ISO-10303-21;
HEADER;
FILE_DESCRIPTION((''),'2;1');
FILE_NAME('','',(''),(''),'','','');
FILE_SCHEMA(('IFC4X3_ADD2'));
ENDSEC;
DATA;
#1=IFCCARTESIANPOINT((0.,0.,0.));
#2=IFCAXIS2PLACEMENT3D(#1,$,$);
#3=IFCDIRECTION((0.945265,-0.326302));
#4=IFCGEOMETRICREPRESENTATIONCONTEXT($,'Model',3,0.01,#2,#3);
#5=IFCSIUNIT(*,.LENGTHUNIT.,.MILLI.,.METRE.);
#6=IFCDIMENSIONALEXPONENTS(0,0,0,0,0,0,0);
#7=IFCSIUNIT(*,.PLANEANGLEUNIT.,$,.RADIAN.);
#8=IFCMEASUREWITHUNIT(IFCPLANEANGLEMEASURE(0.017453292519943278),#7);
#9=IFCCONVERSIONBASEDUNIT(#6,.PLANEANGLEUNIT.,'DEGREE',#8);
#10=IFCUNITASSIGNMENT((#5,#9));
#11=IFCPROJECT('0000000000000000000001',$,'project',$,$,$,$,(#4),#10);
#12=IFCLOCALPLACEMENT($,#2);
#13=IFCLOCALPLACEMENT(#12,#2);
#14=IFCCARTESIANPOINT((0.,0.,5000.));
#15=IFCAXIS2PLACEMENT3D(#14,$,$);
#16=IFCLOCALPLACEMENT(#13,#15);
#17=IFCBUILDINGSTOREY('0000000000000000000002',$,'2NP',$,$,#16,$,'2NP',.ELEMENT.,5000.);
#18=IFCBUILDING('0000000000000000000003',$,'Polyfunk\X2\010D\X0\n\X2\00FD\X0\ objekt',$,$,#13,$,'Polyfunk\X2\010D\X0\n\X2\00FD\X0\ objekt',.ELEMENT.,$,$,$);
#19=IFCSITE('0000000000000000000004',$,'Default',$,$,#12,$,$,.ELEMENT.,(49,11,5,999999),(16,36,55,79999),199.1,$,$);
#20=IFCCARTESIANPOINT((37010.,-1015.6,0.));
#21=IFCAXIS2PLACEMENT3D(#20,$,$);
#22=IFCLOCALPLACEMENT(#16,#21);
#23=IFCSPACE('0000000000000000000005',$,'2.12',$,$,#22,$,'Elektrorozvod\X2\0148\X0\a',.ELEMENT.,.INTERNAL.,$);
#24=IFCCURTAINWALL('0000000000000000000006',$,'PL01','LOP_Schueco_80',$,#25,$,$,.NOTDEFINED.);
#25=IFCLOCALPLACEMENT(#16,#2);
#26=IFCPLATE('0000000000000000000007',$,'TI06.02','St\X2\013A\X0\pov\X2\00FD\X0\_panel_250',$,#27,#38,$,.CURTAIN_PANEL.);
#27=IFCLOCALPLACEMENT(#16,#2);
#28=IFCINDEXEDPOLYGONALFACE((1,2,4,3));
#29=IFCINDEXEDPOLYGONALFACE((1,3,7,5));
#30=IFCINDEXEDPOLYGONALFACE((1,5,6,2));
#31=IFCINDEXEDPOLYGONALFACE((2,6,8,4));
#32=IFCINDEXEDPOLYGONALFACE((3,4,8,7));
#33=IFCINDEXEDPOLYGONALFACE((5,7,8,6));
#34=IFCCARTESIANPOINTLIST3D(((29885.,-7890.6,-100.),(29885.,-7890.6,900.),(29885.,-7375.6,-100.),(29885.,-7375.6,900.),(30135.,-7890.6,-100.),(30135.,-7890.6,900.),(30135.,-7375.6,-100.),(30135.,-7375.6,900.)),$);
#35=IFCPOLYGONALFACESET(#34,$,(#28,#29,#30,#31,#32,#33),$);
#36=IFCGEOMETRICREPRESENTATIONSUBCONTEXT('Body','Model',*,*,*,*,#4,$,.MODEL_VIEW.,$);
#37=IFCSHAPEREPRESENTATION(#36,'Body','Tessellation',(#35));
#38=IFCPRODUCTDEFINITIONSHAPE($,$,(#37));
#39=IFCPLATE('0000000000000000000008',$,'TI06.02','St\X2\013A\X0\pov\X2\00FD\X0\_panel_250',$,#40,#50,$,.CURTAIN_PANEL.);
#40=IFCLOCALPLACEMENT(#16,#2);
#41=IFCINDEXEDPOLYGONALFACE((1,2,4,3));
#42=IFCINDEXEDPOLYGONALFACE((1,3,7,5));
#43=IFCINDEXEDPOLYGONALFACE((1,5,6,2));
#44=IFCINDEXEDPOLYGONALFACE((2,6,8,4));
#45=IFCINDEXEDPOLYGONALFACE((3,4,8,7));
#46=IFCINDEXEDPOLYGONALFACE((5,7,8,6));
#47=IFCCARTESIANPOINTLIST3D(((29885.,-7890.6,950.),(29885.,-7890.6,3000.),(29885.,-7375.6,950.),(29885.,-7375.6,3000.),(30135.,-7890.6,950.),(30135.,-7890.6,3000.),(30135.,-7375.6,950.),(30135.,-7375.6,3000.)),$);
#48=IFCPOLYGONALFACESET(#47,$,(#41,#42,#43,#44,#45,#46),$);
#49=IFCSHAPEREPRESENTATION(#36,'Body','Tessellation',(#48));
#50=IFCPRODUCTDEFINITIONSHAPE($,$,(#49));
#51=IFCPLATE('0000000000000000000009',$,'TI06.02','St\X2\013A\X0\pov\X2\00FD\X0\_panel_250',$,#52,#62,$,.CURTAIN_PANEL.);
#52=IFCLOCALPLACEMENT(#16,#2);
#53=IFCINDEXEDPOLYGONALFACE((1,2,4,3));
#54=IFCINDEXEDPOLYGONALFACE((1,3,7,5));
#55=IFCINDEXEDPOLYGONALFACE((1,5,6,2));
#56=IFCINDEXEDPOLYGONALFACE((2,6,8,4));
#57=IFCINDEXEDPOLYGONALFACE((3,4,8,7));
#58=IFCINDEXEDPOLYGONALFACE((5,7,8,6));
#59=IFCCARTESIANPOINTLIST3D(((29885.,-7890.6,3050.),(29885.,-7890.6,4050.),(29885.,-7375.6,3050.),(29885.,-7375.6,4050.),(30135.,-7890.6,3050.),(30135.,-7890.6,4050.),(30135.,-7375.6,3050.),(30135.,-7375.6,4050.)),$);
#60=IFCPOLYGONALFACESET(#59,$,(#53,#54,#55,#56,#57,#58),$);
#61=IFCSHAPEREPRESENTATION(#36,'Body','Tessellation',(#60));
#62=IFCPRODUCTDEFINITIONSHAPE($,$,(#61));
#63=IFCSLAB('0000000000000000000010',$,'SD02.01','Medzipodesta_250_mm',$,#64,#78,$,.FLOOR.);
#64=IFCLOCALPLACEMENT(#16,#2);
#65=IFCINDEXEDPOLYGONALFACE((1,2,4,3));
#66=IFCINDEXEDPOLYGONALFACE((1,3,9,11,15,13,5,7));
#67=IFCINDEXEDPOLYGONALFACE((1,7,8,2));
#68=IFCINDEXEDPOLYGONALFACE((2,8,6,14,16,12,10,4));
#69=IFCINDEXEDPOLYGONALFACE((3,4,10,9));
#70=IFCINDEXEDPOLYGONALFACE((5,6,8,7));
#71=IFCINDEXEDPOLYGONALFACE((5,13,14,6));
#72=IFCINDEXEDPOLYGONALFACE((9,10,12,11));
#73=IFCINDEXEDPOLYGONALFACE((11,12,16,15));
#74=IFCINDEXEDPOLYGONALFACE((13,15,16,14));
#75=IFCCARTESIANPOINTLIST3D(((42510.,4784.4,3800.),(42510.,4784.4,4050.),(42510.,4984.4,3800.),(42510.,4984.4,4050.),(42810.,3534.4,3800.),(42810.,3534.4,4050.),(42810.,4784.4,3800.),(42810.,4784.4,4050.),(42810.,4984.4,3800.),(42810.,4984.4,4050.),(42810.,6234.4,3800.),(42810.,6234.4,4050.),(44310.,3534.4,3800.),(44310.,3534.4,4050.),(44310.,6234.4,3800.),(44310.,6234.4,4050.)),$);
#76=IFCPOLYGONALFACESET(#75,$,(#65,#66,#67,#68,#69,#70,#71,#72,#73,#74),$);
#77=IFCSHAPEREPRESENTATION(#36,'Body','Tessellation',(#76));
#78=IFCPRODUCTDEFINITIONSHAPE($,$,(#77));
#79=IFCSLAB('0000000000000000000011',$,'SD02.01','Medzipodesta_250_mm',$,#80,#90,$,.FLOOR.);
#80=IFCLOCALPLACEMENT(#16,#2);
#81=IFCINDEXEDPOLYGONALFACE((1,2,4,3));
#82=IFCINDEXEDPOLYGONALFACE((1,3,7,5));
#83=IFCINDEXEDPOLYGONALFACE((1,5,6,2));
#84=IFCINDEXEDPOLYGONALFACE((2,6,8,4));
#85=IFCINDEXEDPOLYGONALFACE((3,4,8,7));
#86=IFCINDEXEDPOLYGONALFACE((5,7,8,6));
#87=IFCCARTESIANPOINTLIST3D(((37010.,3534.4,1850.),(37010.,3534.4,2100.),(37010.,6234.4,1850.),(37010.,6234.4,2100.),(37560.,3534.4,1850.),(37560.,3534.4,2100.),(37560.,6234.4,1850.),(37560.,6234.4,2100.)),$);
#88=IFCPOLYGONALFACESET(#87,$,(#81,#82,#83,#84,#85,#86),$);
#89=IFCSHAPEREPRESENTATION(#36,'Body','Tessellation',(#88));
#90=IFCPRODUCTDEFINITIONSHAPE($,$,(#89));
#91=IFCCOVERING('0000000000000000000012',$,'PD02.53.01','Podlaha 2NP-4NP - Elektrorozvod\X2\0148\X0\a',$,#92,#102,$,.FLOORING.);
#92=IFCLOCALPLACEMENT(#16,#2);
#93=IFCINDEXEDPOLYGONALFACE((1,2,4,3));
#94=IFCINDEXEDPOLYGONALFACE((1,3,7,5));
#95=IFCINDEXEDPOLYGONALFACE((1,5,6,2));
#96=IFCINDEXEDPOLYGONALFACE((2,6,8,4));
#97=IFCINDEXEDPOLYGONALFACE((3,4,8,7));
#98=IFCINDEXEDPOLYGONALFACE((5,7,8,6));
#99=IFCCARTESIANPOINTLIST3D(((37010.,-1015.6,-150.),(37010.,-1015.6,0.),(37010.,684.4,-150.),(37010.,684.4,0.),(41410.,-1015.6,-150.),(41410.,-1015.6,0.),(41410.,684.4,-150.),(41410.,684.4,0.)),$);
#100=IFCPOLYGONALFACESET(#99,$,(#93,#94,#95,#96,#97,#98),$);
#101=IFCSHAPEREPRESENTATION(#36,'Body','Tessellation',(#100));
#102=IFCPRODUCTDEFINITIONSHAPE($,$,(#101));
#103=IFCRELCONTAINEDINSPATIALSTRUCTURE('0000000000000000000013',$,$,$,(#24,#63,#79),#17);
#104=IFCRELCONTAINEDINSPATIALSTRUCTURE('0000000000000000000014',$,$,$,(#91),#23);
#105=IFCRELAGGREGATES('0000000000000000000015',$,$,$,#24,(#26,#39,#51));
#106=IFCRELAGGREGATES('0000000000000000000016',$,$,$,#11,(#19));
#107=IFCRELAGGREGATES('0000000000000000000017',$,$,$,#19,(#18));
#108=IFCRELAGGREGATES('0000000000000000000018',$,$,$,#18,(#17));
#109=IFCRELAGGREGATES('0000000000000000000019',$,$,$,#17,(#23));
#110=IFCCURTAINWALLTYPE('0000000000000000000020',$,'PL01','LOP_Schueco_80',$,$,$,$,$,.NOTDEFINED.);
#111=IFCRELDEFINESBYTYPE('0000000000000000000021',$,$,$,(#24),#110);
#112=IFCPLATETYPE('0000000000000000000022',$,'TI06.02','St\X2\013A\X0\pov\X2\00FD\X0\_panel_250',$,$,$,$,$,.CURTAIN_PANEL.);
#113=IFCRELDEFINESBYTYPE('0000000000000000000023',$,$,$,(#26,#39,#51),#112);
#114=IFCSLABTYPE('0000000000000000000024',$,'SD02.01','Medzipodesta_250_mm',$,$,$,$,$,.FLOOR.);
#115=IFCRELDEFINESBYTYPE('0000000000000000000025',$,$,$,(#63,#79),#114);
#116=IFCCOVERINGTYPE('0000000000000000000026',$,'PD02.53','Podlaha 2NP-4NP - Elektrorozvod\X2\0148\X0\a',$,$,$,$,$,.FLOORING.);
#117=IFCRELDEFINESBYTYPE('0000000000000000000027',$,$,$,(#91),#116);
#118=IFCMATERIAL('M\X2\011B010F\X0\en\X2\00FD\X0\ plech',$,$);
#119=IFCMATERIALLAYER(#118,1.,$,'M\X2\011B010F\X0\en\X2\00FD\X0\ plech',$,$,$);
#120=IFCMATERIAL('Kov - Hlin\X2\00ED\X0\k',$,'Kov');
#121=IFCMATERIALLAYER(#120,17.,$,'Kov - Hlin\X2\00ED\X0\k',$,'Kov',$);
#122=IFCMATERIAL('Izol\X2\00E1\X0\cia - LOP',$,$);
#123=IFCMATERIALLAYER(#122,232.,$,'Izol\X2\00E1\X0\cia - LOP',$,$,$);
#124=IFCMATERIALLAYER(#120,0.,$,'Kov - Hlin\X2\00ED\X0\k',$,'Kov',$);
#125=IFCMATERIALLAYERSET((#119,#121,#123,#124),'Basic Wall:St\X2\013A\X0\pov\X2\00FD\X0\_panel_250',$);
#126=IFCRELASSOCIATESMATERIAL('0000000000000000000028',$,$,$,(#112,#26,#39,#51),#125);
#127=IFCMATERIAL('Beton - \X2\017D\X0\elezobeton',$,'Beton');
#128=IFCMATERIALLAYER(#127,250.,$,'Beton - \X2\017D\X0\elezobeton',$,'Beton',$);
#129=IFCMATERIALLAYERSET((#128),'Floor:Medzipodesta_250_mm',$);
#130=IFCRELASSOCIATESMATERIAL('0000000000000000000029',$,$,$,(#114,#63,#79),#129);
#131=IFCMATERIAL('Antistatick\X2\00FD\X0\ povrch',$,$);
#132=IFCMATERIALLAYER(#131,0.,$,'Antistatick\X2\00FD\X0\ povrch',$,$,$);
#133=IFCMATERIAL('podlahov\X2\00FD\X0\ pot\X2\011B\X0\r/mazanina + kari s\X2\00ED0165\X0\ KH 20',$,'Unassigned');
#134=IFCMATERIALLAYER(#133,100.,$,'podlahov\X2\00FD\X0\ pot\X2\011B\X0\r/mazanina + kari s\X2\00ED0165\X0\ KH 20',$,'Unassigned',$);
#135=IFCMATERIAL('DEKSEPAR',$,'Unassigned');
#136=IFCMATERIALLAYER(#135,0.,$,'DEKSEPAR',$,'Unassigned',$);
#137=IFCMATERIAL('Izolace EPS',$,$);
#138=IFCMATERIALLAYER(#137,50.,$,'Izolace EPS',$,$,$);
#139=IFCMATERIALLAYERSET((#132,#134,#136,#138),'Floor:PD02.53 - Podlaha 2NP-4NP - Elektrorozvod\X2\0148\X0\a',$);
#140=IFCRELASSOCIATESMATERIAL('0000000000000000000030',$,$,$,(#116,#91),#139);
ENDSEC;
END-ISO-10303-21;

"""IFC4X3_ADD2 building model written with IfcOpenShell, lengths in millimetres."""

from ifc_helpers import new_model, entity, si_unit, converted_unit, direction, frame, frame_2d, origin, place, context, subcontext, project, spatial, polyline, rectangle, outline, extrude, material, layer, layer_set, layer_usage, type_object, element, aggregate, save


model = new_model("IFC4X3_ADD2")

# Units and contexts
model_context = context("Model", 3, precision=0.01, world=origin(), true_north=direction((0.945265, -0.326302)))
body_context = subcontext(model_context, "Body", "Model", "MODEL_VIEW")
ifc_project = project(units=[si_unit("LENGTHUNIT", "METRE", prefix="MILLI"), converted_unit("PLANEANGLEUNIT", "DEGREE", entity("IfcPlaneAngleMeasure", 0.017453292519943278), si_unit("PLANEANGLEUNIT", "RADIAN"), dimensions=[0, 0, 0, 0, 0, 0, 0])], contexts=[model_context])

# Site, building, storey
site_placement = place(None, origin())
site = spatial("IfcSite", under=ifc_project, at=site_placement, Name="Default", CompositionType="ELEMENT", RefLatitude=(49, 11, 5, 999999), RefLongitude=(16, 36, 55, 79999), RefElevation=199.1)
building_placement = place(site_placement, origin())
building = spatial("IfcBuilding", under=site, at=building_placement, Name="Polyfunkčný objekt", LongName="Polyfunkčný objekt", CompositionType="ELEMENT")
storey_placement = place(building_placement, frame((0.0, 0.0, 5000.0)))
storey = spatial("IfcBuildingStorey", under=building, at=storey_placement, Name="2NP", LongName="2NP", CompositionType="ELEMENT", Elevation=5000.0)

# Curtain wall
curtain_wall_type = type_object("IfcCurtainWallType", Name="PL01", Description="LOP_Schueco_80", PredefinedType="NOTDEFINED")
curtain_wall_1_placement = place(storey_placement, frame((0.0, 0.0, -5000.0)))
curtain_wall_1 = element("IfcCurtainWall", 1, at=curtain_wall_1_placement, inside=storey, type_object=curtain_wall_type, Name="PL01", Description="LOP_Schueco_80", PredefinedType="NOTDEFINED")

# Shared definitions
ifc_material_1 = material(Name="Beton - Železobeton", Category="Beton")

# Shared definitions
ifc_material_2 = material(Name="Měďený plech")
ifc_layer_1 = layer(ifc_material_2, 1.0, Name="Měďený plech")
ifc_material_3 = material(Name="Kov - Hliník", Category="Kov")
ifc_layer_2 = layer(ifc_material_3, 17.0, Name="Kov - Hliník", Category="Kov")
ifc_material_4 = material(Name="Izolácia - LOP")
ifc_layer_3 = layer(ifc_material_4, 232.0, Name="Izolácia - LOP")
ifc_layer_4 = layer(ifc_material_3, 0.0, Name="Kov - Hliník", Category="Kov")
ifc_layer_set_1 = layer_set([ifc_layer_1, ifc_layer_2, ifc_layer_3, ifc_layer_4], Name="Basic Wall:Stĺpový_panel_250")
plate_type = type_object("IfcPlateType", Name="TI06.02", Description="Stĺpový_panel_250", PredefinedType="CURTAIN_PANEL", material=ifc_layer_set_1)

# Plates
ifc_layer_usage_1 = layer_usage(ifc_layer_set_1, "AXIS2", "POSITIVE", -125.0)
plate_1_placement = place(storey_placement, frame((30010.0, -7375.6, -100.0), z_axis=(0.0, 0.0, 1.0), x_axis=(0.0, -1.0, 0.0)))
plate_1 = element("IfcPlate", 2, at=plate_1_placement, type_object=plate_type, material=ifc_layer_usage_1, Name="TI06.02", Description="Stĺpový_panel_250", PredefinedType="CURTAIN_PANEL", context=body_context, shape_type="SweptSolid", body=[
    extrude(rectangle(XDim=250.0, YDim=515.0, at=frame_2d((0.0, 0.0), x_axis=(1.0, 0.0))), frame((257.5, 0.0, 0.0), z_axis=(0.0, 0.0, 1.0), x_axis=(0.0, 1.0, 0.0)), (0.0, 0.0, 1.0), 1000.0),
])
ifc_layer_usage_2 = layer_usage(ifc_layer_set_1, "AXIS2", "POSITIVE", -125.0)
plate_2_placement = place(storey_placement, frame((30010.0, -7375.6, 950.0), z_axis=(0.0, 0.0, 1.0), x_axis=(0.0, -1.0, 0.0)))
plate_2 = element("IfcPlate", 3, at=plate_2_placement, type_object=plate_type, material=ifc_layer_usage_2, Name="TI06.02", Description="Stĺpový_panel_250", PredefinedType="CURTAIN_PANEL", context=body_context, shape_type="SweptSolid", body=[
    extrude(rectangle(XDim=250.0, YDim=515.0, at=frame_2d((0.0, 0.0), x_axis=(1.0, 0.0))), frame((257.5, 0.0, 0.0), z_axis=(0.0, 0.0, 1.0), x_axis=(0.0, 1.0, 0.0)), (0.0, 0.0, 1.0), 2050.0),
])
ifc_layer_usage_3 = layer_usage(ifc_layer_set_1, "AXIS2", "POSITIVE", -125.0)
plate_3_placement = place(storey_placement, frame((30010.0, -7375.6, 3050.0), z_axis=(0.0, 0.0, 1.0), x_axis=(0.0, -1.0, 0.0)))
plate_3 = element("IfcPlate", 4, at=plate_3_placement, type_object=plate_type, material=ifc_layer_usage_3, Name="TI06.02", Description="Stĺpový_panel_250", PredefinedType="CURTAIN_PANEL", context=body_context, shape_type="SweptSolid", body=[
    extrude(rectangle(XDim=250.0, YDim=515.0, at=frame_2d((0.0, 0.0), x_axis=(1.0, 0.0))), frame((257.5, 0.0, 0.0), z_axis=(0.0, 0.0, 1.0), x_axis=(0.0, 1.0, 0.0)), (0.0, 0.0, 1.0), 1000.0),
])
aggregate(curtain_wall_1, [plate_1, plate_2, plate_3])

# Slabs
ifc_layer_5 = layer(ifc_material_1, 250.0, Name="Beton - Železobeton", Category="Beton")
ifc_layer_set_2 = layer_set([ifc_layer_5], Name="Floor:Medzipodesta_250_mm")
ifc_layer_usage_4 = layer_usage(ifc_layer_set_2, "AXIS3", "POSITIVE", 0.0)
slab_type_1 = type_object("IfcSlabType", Name="SD02.01", Description="Medzipodesta_250_mm", PredefinedType="FLOOR", material=ifc_layer_set_2)
slab_1_placement = place(storey_placement, origin())
element("IfcSlab", 5, at=slab_1_placement, inside=storey, type_object=slab_type_1, material=ifc_layer_usage_4, Name="SD02.01", Description="Medzipodesta_250_mm", PredefinedType="FLOOR", context=body_context, shape_type="SweptSolid", body=[
    extrude(outline(polyline([(-100.0, -600.0), (100.0, -600.0), (100.0, -300.0), (1350.0, -300.0), (1350.0, 1200.0), (-1350.0, 1200.0), (-1350.0, -300.0), (-100.0, -300.0), (-100.0, -600.0)])), frame((43110.0, 4884.4, 4050.0), z_axis=(0.0, 0.0, -1.0), x_axis=(0.0, 1.0, 0.0)), (0.0, 0.0, 1.0), 250.0),
])
ifc_layer_usage_5 = layer_usage(ifc_layer_set_2, "AXIS3", "POSITIVE", 0.0)
slab_2_placement = place(storey_placement, origin())
element("IfcSlab", 6, at=slab_2_placement, inside=storey, type_object=slab_type_1, material=ifc_layer_usage_5, Name="SD02.01", Description="Medzipodesta_250_mm", PredefinedType="FLOOR", context=body_context, shape_type="SweptSolid", body=[
    extrude(rectangle(XDim=2700.0, YDim=550.0, at=frame_2d((0.0, 0.0), x_axis=(1.0, 0.0))), frame((37285.0, 4884.4, 2100.0), z_axis=(0.0, 0.0, -1.0), x_axis=(0.0, 1.0, 0.0)), (0.0, 0.0, 1.0), 250.0),
])

# Shared definitions
ifc_material_5 = material(Name="podlahový potěr/mazanina + kari síť KH 20", Category="Unassigned")
ifc_material_6 = material(Name="DEKSEPAR", Category="Unassigned")
ifc_material_7 = material(Name="Izolace EPS")

# Shared definitions
space_1_placement = place(storey_placement, frame((37010.0, -1015.6, 0.0)))
space_1 = spatial("IfcSpace", under=storey, at=space_1_placement, Name="2.12", LongName="Elektrorozvodňa", CompositionType="ELEMENT", PredefinedType="INTERNAL")

# Covering
ifc_material_8 = material(Name="Antistatický povrch")
ifc_layer_6 = layer(ifc_material_8, 0.0, Name="Antistatický povrch")
ifc_layer_7 = layer(ifc_material_5, 100.0, Name="podlahový potěr/mazanina + kari síť KH 20", Category="Unassigned")
ifc_layer_8 = layer(ifc_material_6, 0.0, Name="DEKSEPAR", Category="Unassigned")
ifc_layer_9 = layer(ifc_material_7, 50.0, Name="Izolace EPS")
ifc_layer_set_3 = layer_set([ifc_layer_6, ifc_layer_7, ifc_layer_8, ifc_layer_9], Name="Floor:PD02.53 - Podlaha 2NP-4NP - Elektrorozvodňa")
ifc_layer_usage_6 = layer_usage(ifc_layer_set_3, "AXIS3", "POSITIVE", 0.0)
covering_type_1 = type_object("IfcCoveringType", Name="PD02.53", Description="Podlaha 2NP-4NP - Elektrorozvodňa", PredefinedType="FLOORING", material=ifc_layer_set_3)
covering_1_placement = place(storey_placement, origin())
element("IfcCovering", 7, at=covering_1_placement, inside=space_1, type_object=covering_type_1, material=ifc_layer_usage_6, Name="PD02.53.01", Description="Podlaha 2NP-4NP - Elektrorozvodňa", PredefinedType="FLOORING", context=body_context, shape_type="SweptSolid", body=[
    extrude(rectangle(XDim=1700.0, YDim=4400.0, at=frame_2d((0.0, 0.0), x_axis=(1.0, 0.0))), frame((39210.0, -165.6, 0.0), z_axis=(0.0, 0.0, -1.0), x_axis=(0.0, 1.0, 0.0)), (0.0, 0.0, 1.0), 150.0),
])

save(model, "model.ifc")
